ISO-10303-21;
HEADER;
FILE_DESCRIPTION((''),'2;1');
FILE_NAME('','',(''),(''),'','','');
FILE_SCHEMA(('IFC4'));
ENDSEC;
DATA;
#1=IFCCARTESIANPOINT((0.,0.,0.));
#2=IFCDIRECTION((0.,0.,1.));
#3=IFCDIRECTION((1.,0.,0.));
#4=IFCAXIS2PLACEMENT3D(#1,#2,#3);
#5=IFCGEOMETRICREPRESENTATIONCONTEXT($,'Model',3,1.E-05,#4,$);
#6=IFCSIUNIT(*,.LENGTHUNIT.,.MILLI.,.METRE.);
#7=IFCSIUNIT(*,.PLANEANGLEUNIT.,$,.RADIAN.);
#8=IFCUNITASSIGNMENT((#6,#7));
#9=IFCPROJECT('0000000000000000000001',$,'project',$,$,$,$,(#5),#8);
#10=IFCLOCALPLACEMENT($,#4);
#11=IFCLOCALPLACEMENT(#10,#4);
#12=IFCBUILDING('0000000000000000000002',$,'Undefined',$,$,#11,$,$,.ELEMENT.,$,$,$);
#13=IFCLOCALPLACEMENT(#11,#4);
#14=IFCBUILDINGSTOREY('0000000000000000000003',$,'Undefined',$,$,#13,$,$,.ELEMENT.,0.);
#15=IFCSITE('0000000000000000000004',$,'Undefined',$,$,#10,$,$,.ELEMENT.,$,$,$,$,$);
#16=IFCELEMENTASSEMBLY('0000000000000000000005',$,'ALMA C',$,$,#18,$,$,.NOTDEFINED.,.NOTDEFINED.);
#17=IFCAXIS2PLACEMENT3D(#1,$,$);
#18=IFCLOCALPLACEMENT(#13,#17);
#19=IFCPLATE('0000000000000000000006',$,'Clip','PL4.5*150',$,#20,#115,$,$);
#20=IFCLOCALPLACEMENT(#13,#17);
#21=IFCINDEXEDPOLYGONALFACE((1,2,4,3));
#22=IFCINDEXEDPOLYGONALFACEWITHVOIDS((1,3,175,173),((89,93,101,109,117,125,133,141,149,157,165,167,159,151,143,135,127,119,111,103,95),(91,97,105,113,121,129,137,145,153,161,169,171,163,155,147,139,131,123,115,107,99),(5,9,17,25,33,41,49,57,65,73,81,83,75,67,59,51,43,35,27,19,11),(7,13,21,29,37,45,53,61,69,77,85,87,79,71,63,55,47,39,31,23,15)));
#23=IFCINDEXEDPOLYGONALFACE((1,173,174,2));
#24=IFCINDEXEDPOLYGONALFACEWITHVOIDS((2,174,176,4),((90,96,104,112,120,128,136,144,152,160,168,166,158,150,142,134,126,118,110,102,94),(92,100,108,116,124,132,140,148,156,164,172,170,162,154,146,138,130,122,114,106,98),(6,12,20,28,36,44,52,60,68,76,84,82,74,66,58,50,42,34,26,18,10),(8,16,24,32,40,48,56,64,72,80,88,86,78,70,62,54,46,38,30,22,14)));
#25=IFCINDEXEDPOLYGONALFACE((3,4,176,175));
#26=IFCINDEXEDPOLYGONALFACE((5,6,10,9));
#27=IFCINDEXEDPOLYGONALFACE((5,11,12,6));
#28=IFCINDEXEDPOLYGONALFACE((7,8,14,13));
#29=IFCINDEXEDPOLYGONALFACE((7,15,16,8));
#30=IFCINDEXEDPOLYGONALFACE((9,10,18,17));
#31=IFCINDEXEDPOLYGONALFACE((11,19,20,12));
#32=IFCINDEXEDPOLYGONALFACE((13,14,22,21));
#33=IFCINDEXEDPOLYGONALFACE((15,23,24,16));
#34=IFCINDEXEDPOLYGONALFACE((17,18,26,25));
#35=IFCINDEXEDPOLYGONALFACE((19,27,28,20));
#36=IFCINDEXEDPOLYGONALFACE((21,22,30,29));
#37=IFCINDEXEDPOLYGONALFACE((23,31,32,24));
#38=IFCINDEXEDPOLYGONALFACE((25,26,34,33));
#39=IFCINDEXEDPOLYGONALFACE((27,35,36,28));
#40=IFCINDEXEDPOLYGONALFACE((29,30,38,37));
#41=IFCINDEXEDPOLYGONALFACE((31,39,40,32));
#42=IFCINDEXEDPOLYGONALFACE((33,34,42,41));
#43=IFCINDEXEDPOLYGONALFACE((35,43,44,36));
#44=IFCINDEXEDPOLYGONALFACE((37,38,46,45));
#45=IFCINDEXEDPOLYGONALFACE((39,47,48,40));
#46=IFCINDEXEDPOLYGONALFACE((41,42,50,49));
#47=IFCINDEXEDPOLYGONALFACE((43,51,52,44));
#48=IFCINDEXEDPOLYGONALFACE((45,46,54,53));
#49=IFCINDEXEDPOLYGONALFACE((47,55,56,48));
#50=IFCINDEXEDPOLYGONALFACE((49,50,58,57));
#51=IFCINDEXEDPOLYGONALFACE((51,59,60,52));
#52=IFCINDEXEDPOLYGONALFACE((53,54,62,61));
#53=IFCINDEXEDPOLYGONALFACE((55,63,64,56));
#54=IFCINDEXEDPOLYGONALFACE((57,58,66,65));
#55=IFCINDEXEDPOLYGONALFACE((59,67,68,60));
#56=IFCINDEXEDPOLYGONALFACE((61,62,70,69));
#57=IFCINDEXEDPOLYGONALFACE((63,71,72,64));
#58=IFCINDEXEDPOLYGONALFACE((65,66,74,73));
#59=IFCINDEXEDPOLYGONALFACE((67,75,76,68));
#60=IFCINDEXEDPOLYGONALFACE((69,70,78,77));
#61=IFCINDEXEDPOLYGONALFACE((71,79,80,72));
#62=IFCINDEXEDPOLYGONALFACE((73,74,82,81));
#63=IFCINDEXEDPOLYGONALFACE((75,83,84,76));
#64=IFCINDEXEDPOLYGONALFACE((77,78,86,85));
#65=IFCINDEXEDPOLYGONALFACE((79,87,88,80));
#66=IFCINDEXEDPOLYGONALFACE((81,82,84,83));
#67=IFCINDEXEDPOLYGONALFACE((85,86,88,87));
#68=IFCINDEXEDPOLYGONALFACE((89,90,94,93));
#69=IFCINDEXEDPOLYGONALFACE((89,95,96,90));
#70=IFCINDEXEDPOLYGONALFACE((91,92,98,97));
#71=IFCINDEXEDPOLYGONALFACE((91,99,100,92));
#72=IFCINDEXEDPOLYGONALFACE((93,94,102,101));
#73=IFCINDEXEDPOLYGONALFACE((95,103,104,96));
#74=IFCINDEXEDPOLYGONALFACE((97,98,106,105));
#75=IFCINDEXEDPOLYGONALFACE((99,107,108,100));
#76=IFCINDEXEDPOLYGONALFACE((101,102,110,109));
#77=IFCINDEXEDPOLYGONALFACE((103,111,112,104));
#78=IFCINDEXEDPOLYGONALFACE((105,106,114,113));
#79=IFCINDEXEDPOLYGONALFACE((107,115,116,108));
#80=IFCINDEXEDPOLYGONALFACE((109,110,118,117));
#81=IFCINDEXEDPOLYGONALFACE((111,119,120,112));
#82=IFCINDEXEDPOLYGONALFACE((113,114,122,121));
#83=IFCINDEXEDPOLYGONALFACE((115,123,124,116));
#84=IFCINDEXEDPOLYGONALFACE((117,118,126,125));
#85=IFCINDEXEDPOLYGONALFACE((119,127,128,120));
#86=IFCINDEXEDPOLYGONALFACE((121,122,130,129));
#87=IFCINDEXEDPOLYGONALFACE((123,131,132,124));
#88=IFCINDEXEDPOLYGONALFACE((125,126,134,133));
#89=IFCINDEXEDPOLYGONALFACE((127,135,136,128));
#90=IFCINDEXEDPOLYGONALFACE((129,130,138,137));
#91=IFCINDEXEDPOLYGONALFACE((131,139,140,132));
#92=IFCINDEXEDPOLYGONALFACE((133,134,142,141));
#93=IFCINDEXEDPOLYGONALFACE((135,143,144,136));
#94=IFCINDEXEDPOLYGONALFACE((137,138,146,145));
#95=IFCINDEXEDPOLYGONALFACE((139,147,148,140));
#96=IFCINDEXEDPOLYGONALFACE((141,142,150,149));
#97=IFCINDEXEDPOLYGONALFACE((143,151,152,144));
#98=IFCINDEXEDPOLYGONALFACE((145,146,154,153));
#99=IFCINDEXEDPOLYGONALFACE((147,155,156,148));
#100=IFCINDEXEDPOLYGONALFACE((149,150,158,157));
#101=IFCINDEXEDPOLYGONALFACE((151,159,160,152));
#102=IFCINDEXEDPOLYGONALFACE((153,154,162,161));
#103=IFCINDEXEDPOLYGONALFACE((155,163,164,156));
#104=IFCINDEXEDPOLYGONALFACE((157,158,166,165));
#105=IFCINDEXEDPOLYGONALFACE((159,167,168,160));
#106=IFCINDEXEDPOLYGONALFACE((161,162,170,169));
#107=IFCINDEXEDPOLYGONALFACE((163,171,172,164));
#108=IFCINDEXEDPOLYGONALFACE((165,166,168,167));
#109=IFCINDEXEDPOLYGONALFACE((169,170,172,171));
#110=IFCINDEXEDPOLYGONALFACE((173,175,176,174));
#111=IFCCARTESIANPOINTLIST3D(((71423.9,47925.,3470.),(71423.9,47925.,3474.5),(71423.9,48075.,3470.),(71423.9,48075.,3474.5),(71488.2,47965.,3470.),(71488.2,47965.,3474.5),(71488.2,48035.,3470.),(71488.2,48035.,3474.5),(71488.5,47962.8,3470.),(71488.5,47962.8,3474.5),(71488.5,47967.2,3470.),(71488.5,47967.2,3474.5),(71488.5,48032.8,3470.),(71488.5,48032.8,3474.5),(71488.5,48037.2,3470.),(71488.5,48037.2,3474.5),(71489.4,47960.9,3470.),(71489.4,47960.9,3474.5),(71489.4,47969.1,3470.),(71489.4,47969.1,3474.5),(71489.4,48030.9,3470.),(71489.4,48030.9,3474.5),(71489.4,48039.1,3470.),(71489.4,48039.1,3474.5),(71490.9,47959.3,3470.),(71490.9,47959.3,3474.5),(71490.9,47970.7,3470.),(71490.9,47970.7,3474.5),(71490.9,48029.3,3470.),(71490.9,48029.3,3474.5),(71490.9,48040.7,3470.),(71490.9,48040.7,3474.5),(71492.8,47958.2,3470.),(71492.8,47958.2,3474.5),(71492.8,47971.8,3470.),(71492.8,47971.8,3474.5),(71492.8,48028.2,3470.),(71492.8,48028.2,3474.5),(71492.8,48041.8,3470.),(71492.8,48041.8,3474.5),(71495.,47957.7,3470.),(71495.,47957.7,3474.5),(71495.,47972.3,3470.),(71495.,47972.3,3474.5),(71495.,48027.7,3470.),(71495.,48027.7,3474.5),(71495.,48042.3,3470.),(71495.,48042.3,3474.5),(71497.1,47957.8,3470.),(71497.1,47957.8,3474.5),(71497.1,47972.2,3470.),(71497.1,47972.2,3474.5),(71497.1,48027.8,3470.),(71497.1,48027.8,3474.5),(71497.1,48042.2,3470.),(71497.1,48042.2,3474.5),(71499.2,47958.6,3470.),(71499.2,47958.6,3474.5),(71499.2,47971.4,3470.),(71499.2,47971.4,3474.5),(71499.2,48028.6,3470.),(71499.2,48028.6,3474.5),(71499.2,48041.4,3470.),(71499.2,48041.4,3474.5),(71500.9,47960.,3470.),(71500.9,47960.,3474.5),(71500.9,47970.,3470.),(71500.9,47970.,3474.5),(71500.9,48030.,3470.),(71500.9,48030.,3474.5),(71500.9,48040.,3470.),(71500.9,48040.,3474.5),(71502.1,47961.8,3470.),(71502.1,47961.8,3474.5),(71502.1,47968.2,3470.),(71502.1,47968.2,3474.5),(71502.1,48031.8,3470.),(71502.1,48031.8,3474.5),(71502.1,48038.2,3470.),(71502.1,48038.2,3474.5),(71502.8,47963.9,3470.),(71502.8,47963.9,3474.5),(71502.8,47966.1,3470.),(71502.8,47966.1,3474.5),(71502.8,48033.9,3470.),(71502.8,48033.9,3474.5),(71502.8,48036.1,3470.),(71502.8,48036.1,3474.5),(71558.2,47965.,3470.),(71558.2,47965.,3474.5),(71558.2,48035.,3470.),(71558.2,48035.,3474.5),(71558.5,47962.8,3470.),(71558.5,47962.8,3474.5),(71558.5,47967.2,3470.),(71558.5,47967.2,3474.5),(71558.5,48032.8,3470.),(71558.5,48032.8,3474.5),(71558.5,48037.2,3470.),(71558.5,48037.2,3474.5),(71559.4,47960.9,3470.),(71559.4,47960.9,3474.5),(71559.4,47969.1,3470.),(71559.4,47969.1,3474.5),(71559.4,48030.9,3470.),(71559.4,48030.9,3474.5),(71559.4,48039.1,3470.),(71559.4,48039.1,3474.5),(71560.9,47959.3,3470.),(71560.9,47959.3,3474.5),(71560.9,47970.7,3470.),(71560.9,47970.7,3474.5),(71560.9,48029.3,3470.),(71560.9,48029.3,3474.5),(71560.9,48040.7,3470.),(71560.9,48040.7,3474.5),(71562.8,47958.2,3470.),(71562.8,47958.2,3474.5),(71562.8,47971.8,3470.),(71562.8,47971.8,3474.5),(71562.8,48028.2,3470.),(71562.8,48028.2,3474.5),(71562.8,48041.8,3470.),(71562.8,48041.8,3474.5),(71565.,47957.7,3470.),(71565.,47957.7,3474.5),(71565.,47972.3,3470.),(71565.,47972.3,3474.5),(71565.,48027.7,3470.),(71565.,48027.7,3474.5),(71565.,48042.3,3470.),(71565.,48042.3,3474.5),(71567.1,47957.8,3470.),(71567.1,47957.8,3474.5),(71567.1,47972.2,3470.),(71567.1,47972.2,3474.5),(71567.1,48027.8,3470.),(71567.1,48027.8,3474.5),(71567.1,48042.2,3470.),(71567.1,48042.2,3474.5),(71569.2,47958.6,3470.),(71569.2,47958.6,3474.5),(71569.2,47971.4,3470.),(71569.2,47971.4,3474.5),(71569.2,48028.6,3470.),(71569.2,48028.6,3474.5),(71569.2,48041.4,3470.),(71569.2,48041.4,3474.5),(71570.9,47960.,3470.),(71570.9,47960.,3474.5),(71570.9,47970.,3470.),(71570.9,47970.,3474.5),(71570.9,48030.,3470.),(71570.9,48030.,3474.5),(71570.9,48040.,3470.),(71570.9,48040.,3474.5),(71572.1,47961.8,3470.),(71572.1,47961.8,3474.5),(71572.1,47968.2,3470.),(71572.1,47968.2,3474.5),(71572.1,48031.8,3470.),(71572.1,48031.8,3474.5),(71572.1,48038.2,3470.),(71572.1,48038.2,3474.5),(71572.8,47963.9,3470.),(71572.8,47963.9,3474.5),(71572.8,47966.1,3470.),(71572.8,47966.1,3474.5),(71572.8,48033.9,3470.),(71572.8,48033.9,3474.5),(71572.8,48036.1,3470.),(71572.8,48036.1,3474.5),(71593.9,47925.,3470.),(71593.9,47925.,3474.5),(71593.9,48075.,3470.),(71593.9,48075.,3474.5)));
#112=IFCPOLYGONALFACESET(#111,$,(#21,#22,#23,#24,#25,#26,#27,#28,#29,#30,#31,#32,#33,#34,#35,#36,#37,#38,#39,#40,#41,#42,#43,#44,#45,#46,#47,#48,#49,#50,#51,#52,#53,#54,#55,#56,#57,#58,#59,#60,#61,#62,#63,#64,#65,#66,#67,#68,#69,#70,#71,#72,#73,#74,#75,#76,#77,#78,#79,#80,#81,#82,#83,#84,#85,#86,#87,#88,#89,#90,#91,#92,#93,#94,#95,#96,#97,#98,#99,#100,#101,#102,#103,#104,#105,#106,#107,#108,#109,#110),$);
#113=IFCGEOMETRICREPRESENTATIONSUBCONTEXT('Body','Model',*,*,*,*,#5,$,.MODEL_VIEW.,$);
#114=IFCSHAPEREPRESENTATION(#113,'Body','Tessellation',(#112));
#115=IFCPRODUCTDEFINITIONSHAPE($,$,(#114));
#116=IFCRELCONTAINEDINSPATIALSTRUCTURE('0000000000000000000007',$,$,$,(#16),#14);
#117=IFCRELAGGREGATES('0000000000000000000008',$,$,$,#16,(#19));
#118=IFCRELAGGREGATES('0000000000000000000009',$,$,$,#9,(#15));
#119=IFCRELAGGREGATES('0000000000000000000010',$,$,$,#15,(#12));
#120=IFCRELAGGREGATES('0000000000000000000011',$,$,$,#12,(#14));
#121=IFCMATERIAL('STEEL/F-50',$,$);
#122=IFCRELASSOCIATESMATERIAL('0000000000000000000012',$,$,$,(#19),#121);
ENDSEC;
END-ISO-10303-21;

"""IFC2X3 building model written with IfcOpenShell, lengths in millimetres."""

from ifc_helpers import new_model, si_unit, frame, origin_with_axes, origin_2d_with_axis, place, context, subcontext, project, spatial, polyline, circle, outline, extrude, source, transform, mapped, material, element, aggregate, save


model = new_model("IFC2X3")

# Units and contexts
model_context = context("Model", 3, precision=1e-05, world=origin_with_axes())
body_context = subcontext(model_context, "Body", "Model", "MODEL_VIEW")
ifc_project = project(units=[si_unit("LENGTHUNIT", "METRE", prefix="MILLI"), si_unit("PLANEANGLEUNIT", "RADIAN")], contexts=[model_context])

# Site, building, storey
site_placement = place(None, origin_with_axes())
site = spatial("IfcSite", under=ifc_project, at=site_placement, Name="Undefined", CompositionType="ELEMENT")
building_placement = place(site_placement, origin_with_axes())
building = spatial("IfcBuilding", under=site, at=building_placement, Name="Undefined", CompositionType="ELEMENT")
storey_placement = place(building_placement, origin_with_axes())
storey = spatial("IfcBuildingStorey", under=building, at=storey_placement, Name="Undefined", CompositionType="ELEMENT", Elevation=0.0)

# Element assembly
assembly_1_placement = place(storey_placement, origin_with_axes())
assembly_1 = element("IfcElementAssembly", 1, at=assembly_1_placement, inside=storey, Name="ALMA C", AssemblyPlace="NOTDEFINED", PredefinedType="NOTDEFINED")
ifc_material_1 = material(Name="STEEL/F-50")

# Plate, openings
plate_1_placement = place(assembly_1_placement, frame((71423.9, 48075.0, 3472.2), z_axis=(0.0, 0.0, -1.0), x_axis=(1.0, 0.0, 0.0)))
plate_1 = element("IfcPlate", 2, at=plate_1_placement, material=ifc_material_1, Name="Clip", Description="PL4.5*150", context=body_context, shape_type="SweptSolid", body=[
    extrude(outline(polyline([(0.0, 0.0), (170.0, 0.0), (170.0, 150.0), (0.0, 150.0), (0.0, 0.0)])), frame((0.0, 0.0, -2.2), z_axis=(0.0, 0.0, 1.0), x_axis=(1.0, 0.0, 0.0)), (0.0, 0.0, 1.0), 4.5),
])
shared_shape_1 = source(origin_with_axes(), body_context, "Body", "SweptSolid", [
    extrude(circle(Radius=7.3, at=origin_2d_with_axis()), frame((0.0, -4.6, 0.0), z_axis=(0.0, 1.0, 0.0), x_axis=(1.0, 0.0, 0.0)), (0.0, 0.0, 1.0), 4.7),
])
opening_1_placement = place(assembly_1_placement, frame((71565.5, 47965.0, 3470.0), z_axis=(0.0, -1.0, 0.0), x_axis=(-1.0, 0.0, 0.0)))
element("IfcOpeningElement", 3, at=opening_1_placement, cuts=plate_1, ObjectType="Opening", context=body_context, shape_type="MappedRepresentation", body=[
    mapped(shared_shape_1, transform((0.0, 0.0, 0.0))),
    mapped(shared_shape_1, transform((70.0, 0.0, 0.0))),
])
opening_2_placement = place(assembly_1_placement, frame((71565.5, 48035.0, 3470.0), z_axis=(0.0, -1.0, 0.0), x_axis=(-1.0, 0.0, 0.0)))
element("IfcOpeningElement", 4, at=opening_2_placement, cuts=plate_1, ObjectType="Opening", context=body_context, shape_type="MappedRepresentation", body=[
    mapped(shared_shape_1, transform((0.0, 0.0, 0.0))),
    mapped(shared_shape_1, transform((70.0, 0.0, 0.0))),
])

aggregate(assembly_1, [plate_1])

save(model, "model.ifc")
